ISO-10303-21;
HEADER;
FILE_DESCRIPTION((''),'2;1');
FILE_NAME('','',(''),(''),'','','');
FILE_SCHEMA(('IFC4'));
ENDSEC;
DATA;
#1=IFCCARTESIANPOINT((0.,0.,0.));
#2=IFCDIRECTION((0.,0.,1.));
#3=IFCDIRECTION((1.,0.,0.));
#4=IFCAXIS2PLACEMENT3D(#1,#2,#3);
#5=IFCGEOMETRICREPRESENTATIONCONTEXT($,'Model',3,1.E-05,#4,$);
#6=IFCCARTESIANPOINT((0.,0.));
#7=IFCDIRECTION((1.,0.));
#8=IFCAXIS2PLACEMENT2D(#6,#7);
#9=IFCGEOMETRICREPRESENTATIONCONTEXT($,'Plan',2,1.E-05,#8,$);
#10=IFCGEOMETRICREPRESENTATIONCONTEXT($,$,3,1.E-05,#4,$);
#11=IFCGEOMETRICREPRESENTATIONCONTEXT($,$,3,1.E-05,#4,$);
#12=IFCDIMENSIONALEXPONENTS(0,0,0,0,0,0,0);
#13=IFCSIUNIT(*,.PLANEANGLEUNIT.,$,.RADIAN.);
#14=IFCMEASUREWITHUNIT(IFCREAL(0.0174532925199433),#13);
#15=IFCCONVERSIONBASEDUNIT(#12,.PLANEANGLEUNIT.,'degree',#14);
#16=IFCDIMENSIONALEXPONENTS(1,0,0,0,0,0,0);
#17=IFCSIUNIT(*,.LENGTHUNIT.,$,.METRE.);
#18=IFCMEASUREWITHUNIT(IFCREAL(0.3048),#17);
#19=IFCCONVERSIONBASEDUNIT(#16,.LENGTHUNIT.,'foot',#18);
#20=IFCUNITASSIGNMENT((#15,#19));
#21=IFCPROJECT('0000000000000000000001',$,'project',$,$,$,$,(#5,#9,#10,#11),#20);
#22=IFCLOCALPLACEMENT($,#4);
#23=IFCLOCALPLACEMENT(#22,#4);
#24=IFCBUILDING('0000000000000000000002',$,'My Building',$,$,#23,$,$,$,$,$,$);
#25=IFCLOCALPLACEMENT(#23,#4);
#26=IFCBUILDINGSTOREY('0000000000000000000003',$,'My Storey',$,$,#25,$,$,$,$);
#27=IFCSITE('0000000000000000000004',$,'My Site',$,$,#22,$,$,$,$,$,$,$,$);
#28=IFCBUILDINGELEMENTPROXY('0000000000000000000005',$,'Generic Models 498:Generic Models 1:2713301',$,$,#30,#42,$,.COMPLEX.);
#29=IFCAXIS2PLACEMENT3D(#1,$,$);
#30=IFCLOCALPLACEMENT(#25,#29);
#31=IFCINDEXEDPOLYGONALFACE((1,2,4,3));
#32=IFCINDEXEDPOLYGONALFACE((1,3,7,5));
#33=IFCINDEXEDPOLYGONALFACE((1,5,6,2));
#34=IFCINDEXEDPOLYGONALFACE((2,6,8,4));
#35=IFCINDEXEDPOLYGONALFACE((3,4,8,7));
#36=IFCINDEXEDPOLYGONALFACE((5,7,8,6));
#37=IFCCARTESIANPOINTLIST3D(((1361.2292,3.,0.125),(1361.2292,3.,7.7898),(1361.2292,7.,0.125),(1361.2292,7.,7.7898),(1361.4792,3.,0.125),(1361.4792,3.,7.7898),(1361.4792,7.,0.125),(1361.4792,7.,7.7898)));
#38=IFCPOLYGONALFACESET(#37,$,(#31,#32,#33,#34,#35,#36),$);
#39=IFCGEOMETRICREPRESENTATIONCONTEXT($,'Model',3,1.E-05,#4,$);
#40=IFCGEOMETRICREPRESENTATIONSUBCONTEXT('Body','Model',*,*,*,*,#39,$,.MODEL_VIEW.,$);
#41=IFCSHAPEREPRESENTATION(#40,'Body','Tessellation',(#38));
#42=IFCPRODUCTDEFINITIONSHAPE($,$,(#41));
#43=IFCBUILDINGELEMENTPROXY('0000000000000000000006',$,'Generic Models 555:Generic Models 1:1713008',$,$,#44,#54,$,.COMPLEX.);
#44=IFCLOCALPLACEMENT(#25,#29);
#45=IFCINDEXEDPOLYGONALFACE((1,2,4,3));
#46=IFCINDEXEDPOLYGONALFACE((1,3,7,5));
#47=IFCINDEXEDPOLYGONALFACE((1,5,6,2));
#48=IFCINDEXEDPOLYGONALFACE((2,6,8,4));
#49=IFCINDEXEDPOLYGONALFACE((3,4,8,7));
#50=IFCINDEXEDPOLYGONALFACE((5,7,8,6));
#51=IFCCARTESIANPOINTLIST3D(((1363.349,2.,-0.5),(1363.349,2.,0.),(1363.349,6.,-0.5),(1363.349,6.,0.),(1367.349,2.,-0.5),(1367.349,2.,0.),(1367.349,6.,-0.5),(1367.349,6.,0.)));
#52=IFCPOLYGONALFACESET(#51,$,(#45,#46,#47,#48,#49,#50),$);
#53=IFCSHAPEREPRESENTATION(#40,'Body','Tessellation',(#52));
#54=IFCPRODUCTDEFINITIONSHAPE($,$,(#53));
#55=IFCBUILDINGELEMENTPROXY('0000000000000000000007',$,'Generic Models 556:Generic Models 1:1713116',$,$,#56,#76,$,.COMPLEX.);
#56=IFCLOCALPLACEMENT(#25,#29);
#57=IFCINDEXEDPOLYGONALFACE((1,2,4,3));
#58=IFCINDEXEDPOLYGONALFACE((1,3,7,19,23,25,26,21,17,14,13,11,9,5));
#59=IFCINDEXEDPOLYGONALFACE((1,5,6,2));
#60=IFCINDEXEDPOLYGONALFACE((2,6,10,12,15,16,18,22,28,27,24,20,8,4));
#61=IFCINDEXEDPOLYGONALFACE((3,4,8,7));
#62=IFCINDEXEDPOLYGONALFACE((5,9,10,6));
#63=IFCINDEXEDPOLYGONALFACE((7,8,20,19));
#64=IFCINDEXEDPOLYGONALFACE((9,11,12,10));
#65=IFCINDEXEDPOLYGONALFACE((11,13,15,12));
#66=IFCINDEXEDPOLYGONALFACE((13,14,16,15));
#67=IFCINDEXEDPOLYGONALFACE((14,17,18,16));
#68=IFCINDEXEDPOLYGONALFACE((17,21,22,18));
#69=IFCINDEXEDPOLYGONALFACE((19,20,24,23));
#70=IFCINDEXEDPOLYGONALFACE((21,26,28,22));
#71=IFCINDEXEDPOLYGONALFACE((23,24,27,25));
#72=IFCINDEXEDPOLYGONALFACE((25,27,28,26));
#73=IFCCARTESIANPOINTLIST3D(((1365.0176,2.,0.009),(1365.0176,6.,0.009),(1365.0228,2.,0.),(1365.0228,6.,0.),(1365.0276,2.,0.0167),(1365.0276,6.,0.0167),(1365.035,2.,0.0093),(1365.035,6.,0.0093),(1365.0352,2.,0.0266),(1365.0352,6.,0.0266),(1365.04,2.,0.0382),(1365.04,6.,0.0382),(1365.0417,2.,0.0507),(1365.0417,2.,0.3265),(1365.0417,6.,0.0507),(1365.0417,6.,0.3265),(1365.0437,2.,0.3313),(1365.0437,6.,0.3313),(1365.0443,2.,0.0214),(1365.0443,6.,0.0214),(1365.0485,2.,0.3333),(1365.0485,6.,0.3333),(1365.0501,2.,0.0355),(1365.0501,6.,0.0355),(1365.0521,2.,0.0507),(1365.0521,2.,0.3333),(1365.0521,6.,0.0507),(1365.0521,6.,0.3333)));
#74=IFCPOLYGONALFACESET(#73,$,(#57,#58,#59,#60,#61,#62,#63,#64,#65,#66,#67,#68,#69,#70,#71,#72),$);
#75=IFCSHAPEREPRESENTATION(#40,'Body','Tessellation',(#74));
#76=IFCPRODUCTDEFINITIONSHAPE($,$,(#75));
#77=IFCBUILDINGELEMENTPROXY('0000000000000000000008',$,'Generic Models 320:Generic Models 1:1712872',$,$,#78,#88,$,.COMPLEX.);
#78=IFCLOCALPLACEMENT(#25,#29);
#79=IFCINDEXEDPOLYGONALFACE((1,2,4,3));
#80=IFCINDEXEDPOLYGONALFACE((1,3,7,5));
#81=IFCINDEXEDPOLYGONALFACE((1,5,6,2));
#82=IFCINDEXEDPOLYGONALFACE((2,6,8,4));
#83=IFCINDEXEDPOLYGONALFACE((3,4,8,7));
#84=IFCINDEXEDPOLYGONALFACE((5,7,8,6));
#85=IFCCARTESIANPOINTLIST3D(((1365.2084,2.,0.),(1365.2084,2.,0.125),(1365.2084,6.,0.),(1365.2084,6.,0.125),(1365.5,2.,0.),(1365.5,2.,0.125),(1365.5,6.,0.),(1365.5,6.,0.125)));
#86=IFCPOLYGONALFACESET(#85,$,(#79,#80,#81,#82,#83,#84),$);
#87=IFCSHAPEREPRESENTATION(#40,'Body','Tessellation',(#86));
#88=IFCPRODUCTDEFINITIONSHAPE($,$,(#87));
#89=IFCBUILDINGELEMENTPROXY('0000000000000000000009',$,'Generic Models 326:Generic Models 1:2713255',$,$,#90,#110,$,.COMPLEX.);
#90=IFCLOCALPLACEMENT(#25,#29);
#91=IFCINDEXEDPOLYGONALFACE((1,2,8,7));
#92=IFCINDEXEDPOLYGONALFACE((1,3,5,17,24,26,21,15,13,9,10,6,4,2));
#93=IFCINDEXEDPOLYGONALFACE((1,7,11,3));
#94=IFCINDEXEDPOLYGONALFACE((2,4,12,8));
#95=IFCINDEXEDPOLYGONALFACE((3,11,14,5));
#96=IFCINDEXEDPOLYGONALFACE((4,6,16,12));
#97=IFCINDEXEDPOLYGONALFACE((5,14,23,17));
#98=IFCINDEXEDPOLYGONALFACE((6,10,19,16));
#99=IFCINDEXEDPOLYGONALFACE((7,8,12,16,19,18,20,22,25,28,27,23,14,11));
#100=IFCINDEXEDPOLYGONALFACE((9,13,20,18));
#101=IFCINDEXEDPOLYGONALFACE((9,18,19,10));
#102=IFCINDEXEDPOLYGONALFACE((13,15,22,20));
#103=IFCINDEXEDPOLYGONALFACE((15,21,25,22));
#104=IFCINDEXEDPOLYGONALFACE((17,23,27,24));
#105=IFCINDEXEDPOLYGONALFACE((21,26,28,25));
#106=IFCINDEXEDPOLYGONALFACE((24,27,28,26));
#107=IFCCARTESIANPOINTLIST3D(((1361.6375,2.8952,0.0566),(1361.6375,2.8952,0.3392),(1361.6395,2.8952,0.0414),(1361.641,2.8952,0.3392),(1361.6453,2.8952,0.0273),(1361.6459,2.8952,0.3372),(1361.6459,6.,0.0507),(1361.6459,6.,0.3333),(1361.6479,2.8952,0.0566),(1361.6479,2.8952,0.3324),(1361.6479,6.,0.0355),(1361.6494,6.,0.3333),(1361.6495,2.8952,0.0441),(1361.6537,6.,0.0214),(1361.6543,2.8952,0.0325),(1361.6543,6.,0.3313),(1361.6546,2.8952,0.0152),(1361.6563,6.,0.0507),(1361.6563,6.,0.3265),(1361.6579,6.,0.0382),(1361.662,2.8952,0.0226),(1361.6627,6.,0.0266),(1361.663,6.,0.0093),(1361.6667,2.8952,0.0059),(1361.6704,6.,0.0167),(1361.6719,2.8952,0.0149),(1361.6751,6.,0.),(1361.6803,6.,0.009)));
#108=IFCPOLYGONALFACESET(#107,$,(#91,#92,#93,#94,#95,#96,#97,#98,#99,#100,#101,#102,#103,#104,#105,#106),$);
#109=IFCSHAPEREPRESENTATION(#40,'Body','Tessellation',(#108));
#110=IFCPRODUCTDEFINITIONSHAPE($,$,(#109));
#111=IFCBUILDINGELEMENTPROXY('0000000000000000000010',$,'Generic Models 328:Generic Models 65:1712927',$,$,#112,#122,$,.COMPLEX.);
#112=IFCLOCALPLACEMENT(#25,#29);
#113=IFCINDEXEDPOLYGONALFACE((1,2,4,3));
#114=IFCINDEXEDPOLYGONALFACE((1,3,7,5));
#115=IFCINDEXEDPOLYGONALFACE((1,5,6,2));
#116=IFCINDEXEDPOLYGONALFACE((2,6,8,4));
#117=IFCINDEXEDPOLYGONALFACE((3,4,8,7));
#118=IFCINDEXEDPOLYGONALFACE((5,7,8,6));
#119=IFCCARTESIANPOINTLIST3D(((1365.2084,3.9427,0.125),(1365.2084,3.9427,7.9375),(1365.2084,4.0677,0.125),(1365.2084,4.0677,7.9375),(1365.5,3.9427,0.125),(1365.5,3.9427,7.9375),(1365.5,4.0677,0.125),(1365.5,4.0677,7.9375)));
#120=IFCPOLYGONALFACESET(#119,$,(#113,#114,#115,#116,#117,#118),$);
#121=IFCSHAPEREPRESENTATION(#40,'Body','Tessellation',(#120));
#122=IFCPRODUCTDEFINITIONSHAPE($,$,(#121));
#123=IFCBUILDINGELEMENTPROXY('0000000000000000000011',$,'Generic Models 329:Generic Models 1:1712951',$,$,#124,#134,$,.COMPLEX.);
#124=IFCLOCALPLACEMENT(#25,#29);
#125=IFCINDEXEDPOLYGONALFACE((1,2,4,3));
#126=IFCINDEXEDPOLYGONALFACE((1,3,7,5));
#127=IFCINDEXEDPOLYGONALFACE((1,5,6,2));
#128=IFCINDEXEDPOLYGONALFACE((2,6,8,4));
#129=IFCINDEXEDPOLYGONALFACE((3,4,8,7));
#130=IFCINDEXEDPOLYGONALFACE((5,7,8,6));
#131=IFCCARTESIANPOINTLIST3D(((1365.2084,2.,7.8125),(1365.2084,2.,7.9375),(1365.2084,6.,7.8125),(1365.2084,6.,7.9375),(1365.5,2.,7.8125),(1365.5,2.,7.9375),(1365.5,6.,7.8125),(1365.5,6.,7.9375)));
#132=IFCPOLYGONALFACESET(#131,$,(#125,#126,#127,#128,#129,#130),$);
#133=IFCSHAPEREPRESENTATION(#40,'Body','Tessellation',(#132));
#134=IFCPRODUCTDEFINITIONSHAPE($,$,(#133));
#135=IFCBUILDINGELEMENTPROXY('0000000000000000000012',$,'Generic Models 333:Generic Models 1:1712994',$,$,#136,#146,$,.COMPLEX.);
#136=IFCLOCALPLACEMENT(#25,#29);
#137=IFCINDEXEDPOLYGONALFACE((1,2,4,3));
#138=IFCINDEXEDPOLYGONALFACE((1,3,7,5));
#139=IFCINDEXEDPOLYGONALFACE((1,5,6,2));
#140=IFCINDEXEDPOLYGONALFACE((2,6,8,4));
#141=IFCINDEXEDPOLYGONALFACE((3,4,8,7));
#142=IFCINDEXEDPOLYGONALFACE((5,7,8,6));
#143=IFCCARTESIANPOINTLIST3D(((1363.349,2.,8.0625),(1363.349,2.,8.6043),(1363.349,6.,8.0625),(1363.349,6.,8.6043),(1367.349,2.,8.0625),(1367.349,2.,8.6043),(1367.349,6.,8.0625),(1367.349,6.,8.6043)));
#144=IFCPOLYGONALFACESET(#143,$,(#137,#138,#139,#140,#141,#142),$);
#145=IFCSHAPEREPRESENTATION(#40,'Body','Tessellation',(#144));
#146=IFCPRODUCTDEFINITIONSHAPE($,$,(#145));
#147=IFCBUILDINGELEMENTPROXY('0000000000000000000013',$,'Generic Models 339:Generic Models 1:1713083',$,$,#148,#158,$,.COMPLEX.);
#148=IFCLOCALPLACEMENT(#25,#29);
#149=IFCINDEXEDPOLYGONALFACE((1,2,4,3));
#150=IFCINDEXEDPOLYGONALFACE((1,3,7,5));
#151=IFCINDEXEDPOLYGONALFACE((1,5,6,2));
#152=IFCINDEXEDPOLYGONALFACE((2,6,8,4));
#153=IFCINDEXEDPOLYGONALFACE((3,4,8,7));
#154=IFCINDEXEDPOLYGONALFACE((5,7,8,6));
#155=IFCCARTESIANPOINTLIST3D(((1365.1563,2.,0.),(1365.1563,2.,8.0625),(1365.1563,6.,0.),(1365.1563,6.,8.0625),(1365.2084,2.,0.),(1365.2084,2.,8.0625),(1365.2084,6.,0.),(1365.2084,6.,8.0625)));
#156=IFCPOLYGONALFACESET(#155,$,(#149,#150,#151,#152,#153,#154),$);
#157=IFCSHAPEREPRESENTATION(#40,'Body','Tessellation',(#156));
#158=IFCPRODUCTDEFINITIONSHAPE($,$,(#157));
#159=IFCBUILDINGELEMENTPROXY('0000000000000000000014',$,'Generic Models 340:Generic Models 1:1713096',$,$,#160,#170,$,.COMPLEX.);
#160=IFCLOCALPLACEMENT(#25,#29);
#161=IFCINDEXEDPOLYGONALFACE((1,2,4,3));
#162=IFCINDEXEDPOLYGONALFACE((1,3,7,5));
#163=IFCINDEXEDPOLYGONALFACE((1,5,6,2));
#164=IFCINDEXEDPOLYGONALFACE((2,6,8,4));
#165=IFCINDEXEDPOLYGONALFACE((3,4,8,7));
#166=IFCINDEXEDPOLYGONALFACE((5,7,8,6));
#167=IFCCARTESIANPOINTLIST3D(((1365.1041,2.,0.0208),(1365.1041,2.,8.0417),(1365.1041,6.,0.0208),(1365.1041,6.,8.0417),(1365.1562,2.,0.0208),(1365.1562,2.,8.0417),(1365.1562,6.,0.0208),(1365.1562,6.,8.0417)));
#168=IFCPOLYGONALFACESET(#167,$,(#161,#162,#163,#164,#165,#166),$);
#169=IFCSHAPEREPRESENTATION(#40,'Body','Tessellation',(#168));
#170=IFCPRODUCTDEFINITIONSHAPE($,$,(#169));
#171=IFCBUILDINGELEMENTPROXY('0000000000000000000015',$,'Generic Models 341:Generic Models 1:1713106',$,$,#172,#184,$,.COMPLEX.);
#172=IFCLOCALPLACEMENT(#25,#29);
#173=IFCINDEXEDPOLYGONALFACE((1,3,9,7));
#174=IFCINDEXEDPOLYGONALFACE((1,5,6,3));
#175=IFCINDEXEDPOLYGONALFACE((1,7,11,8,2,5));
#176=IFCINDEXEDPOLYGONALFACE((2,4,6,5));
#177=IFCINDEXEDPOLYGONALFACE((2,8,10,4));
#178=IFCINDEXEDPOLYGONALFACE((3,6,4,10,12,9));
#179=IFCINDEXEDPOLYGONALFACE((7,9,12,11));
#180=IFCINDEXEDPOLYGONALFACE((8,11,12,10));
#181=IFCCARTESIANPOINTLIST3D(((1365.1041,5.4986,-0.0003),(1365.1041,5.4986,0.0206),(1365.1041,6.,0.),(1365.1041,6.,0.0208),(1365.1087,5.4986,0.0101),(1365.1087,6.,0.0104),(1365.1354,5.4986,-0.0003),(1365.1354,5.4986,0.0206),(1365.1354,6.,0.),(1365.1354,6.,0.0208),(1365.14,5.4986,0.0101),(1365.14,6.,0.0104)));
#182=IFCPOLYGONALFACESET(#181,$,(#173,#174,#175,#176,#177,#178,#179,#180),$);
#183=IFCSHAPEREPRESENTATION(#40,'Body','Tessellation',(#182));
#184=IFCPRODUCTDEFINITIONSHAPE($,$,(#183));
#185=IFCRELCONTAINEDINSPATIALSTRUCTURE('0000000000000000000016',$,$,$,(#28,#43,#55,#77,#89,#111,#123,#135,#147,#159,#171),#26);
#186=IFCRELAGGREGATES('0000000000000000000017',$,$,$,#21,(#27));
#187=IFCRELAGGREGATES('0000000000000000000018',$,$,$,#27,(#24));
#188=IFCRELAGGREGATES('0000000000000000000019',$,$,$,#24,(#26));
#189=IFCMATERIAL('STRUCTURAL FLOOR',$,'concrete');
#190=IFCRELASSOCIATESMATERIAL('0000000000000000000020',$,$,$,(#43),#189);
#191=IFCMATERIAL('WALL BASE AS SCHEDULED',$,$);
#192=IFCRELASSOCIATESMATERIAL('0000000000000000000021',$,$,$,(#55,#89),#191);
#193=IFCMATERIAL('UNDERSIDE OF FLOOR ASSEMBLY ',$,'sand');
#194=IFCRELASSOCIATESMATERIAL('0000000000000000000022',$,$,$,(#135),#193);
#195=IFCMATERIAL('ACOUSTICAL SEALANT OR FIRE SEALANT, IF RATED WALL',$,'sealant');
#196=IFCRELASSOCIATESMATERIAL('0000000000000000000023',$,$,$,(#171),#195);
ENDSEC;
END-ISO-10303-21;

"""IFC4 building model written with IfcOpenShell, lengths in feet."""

from ifc_helpers import new_model, entity, si_unit, converted_unit, frame, origin_with_axes, origin_2d_with_axis, place, context, subcontext, project, spatial, polyline, outline, extrude, material, element, save


model = new_model("IFC4")

# Units and contexts
model_context_1 = context("Model", 3, precision=1e-05, world=origin_with_axes())
plan_context = context("Plan", 2, precision=1e-05, world=origin_2d_with_axis())
model_context_2 = context("Model", 3, precision=1e-05, world=origin_with_axes())
context_of_model_1 = context(None, 3, precision=1e-05, world=origin_with_axes())
context_of_model_2 = context(None, 3, precision=1e-05, world=origin_with_axes())
body_context = subcontext(model_context_2, "Body", "Model", "MODEL_VIEW")
ifc_project = project(units=[converted_unit("PLANEANGLEUNIT", "degree", entity("IfcReal", 0.0174532925199433), si_unit("PLANEANGLEUNIT", "RADIAN"), dimensions=[0, 0, 0, 0, 0, 0, 0]), converted_unit("LENGTHUNIT", "foot", entity("IfcReal", 0.3048), si_unit("LENGTHUNIT", "METRE"), dimensions=[1, 0, 0, 0, 0, 0, 0])], contexts=[model_context_1, plan_context, context_of_model_1, context_of_model_2])

# Site, building, storey
site_placement = place(None, origin_with_axes())
site = spatial("IfcSite", under=ifc_project, at=site_placement, Name="My Site")
building_placement = place(site_placement, origin_with_axes())
building = spatial("IfcBuilding", under=site, at=building_placement, Name="My Building")
storey_placement = place(building_placement, origin_with_axes())
storey = spatial("IfcBuildingStorey", under=building, at=storey_placement, Name="My Storey")

# Building element proxies
proxy_1_placement = place(storey_placement, frame((1361.2292, 3.0, 0.125), z_axis=(0.0, 0.0, 1.0), x_axis=(0.0, 1.0, 0.0)))
element("IfcBuildingElementProxy", 1, at=proxy_1_placement, inside=storey, Name="Generic Models 498:Generic Models 1:2713301", PredefinedType="COMPLEX", context=body_context, shape_type="SweptSolid", body=[
    extrude(outline(polyline([(-2.0, -0.125), (2.0, -0.125), (2.0, 0.125), (-2.0, 0.125), (-2.0, -0.125)])), frame((2.0, -0.125, 0.0), z_axis=(0.0, 0.0, -1.0), x_axis=(-1.0, 0.0, 0.0)), (0.0, 0.0, -1.0), 7.6648),
])
ifc_material_1 = material(Name="ACOUSTICAL SEALANT OR FIRE SEALANT, IF RATED WALL", Category="sealant")
ifc_material_2 = material(Name="STRUCTURAL FLOOR", Category="concrete")
proxy_2_placement = place(storey_placement, frame((1363.349, 6.0, -0.5), z_axis=(0.0, -1.0, 0.0), x_axis=(0.0, 0.0, 1.0)))
element("IfcBuildingElementProxy", 2, at=proxy_2_placement, inside=storey, material=ifc_material_2, Name="Generic Models 555:Generic Models 1:1713008", PredefinedType="COMPLEX", context=body_context, shape_type="SweptSolid", body=[
    extrude(outline(polyline([(-0.25, -2.0), (0.25, -2.0), (0.25, 2.0), (-0.25, 2.0), (-0.25, -2.0)])), frame((0.25, -2.0, 0.0), z_axis=(0.0, 0.0, -1.0), x_axis=(1.0, 0.0, 0.0)), (0.0, 0.0, -1.0), 4.0),
])
ifc_material_3 = material(Name="WALL BASE AS SCHEDULED")
proxy_3_placement = place(storey_placement, frame((1365.0176, 6.0, 0.0), z_axis=(0.0, -1.0, 0.0), x_axis=(0.0, 0.0, 1.0)))
element("IfcBuildingElementProxy", 3, at=proxy_3_placement, inside=storey, material=ifc_material_3, Name="Generic Models 556:Generic Models 1:1713116", PredefinedType="COMPLEX", context=body_context, shape_type="SweptSolid", body=[
    extrude(outline(polyline([(0.2205, 0.0), (0.2206, 0.0036), (-0.0618, 0.0152), (-0.077, 0.0138), (-0.0914, 0.0086), (-0.1038, -0.0002), (-0.1136, -0.012), (-0.1048, -0.0175), (-0.0968, -0.0079), (-0.0865, -0.0007), (-0.0747, 0.0037), (-0.0622, 0.0048), (0.2133, -0.0066), (0.2183, -0.0048), (0.2205, 0.0)])), frame((0.113, -0.0218, 0.0), z_axis=(0.0, 0.0, -1.0), x_axis=(0.999153, -0.041137, 0.0)), (0.0, 0.0, -1.0), 4.0),
])
proxy_4_placement = place(storey_placement, frame((1365.2084, 6.0, 0.0), z_axis=(0.0, -1.0, 0.0), x_axis=(0.0, 0.0, 1.0)))
element("IfcBuildingElementProxy", 4, at=proxy_4_placement, inside=storey, Name="Generic Models 320:Generic Models 1:1712872", PredefinedType="COMPLEX", context=body_context, shape_type="SweptSolid", body=[
    extrude(outline(polyline([(-0.0625, -0.1458), (0.0625, -0.1458), (0.0625, 0.1458), (-0.0625, 0.1458), (-0.0625, -0.1458)])), frame((0.0625, -0.1458, 0.0), z_axis=(0.0, 0.0, -1.0), x_axis=(1.0, 0.0, 0.0)), (0.0, 0.0, -1.0), 4.0),
])
proxy_5_placement = place(storey_placement, frame((1361.6459, 6.0, 0.0), z_axis=(0.0, -1.0, 0.0), x_axis=(0.0, 0.0, 1.0)))
element("IfcBuildingElementProxy", 5, at=proxy_5_placement, inside=storey, material=ifc_material_3, Name="Generic Models 326:Generic Models 1:2713255", PredefinedType="COMPLEX", context=body_context, shape_type="SweptSolid", body=[
    extrude(outline(polyline([(-0.2134, 0.0022), (0.0624, 0.0022), (0.0748, 0.0006), (0.0864, -0.0042), (0.0964, -0.0119), (0.104, -0.0218), (0.113, -0.0166), (0.1037, -0.0045), (0.0916, 0.0048), (0.0775, 0.0106), (0.0624, 0.0126), (-0.2203, 0.0126), (-0.2203, 0.0091), (-0.2183, 0.0042), (-0.2134, 0.0022)])), frame((0.113, -0.0126, 0.0), z_axis=(0.0, 0.0, -1.0), x_axis=(-1.0, 0.0, 0.0)), (-0.001902, 0.002712, -0.999995), 3.1048),
])
proxy_6_placement = place(storey_placement, frame((1365.2084, 3.9427, 0.125), z_axis=(0.0, 0.0, 1.0), x_axis=(1.0, 0.0, 0.0)))
element("IfcBuildingElementProxy", 6, at=proxy_6_placement, inside=storey, Name="Generic Models 328:Generic Models 65:1712927", PredefinedType="COMPLEX", context=body_context, shape_type="SweptSolid", body=[
    extrude(outline(polyline([(-0.1458, -0.0625), (0.1458, -0.0625), (0.1458, 0.0625), (-0.1458, 0.0625), (-0.1458, -0.0625)])), frame((0.1458, 0.0625, 0.0), z_axis=(0.0, 0.0, -1.0), x_axis=(-1.0, 0.0, 0.0)), (0.0, 0.0, -1.0), 7.8125),
])
proxy_7_placement = place(storey_placement, frame((1365.2084, 6.0, 7.8125), z_axis=(0.0, -1.0, 0.0), x_axis=(0.0, 0.0, 1.0)))
element("IfcBuildingElementProxy", 7, at=proxy_7_placement, inside=storey, Name="Generic Models 329:Generic Models 1:1712951", PredefinedType="COMPLEX", context=body_context, shape_type="SweptSolid", body=[
    extrude(outline(polyline([(-0.1458, -0.0625), (0.1458, -0.0625), (0.1458, 0.0625), (-0.1458, 0.0625), (-0.1458, -0.0625)])), frame((0.0625, -0.1458, 0.0), z_axis=(0.0, 0.0, -1.0), x_axis=(0.0, 1.0, 0.0)), (0.0, 0.0, -1.0), 4.0),
])
ifc_material_4 = material(Name="UNDERSIDE OF FLOOR ASSEMBLY ", Category="sand")
proxy_8_placement = place(storey_placement, frame((1363.349, 6.0, 8.0625), z_axis=(0.0, -1.0, 0.0), x_axis=(0.0, 0.0, 1.0)))
element("IfcBuildingElementProxy", 8, at=proxy_8_placement, inside=storey, material=ifc_material_4, Name="Generic Models 333:Generic Models 1:1712994", PredefinedType="COMPLEX", context=body_context, shape_type="SweptSolid", body=[
    extrude(outline(polyline([(-0.2709, -2.0), (0.2709, -2.0), (0.2709, 2.0), (-0.2709, 2.0), (-0.2709, -2.0)])), frame((0.2709, -2.0, 0.0), z_axis=(0.0, 0.0, -1.0), x_axis=(1.0, 0.0, 0.0)), (0.0, 0.0, -1.0), 4.0),
])
proxy_9_placement = place(storey_placement, frame((1365.1563, 6.0, 0.0), z_axis=(0.0, -1.0, 0.0), x_axis=(0.0, 0.0, 1.0)))
element("IfcBuildingElementProxy", 9, at=proxy_9_placement, inside=storey, Name="Generic Models 339:Generic Models 1:1713083", PredefinedType="COMPLEX", context=body_context, shape_type="SweptSolid", body=[
    extrude(outline(polyline([(-4.0312, -0.026), (4.0312, -0.026), (4.0312, 0.026), (-4.0312, 0.026), (-4.0312, -0.026)])), frame((4.0312, -0.026, 0.0), z_axis=(0.0, 0.0, -1.0), x_axis=(-1.0, 0.0, 0.0)), (0.0, 0.0, -1.0), 4.0),
])
proxy_10_placement = place(storey_placement, frame((1365.1041, 6.0, 0.0208), z_axis=(0.0, -1.0, 0.0), x_axis=(0.0, 0.0, 1.0)))
element("IfcBuildingElementProxy", 10, at=proxy_10_placement, inside=storey, Name="Generic Models 340:Generic Models 1:1713096", PredefinedType="COMPLEX", context=body_context, shape_type="SweptSolid", body=[
    extrude(outline(polyline([(-0.026, -4.0104), (0.026, -4.0104), (0.026, 4.0104), (-0.026, 4.0104), (-0.026, -4.0104)])), frame((4.0104, -0.026, 0.0), z_axis=(0.0, 0.0, -1.0), x_axis=(0.0, 1.0, 0.0)), (0.0, 0.0, -1.0), 4.0),
])
proxy_11_placement = place(storey_placement, frame((1365.1041, 6.0, 0.0), z_axis=(0.0, -1.0, 0.0), x_axis=(0.0, 0.0, 1.0)))
element("IfcBuildingElementProxy", 11, at=proxy_11_placement, inside=storey, material=ifc_material_1, Name="Generic Models 341:Generic Models 1:1713106", PredefinedType="COMPLEX", context=body_context, shape_type="SweptSolid", body=[
    extrude(outline(polyline([(0.0201, 0.0), (-0.0066, 0.0162), (-0.016, 0.0097), (-0.0175, -0.0016), (0.0093, -0.0178), (0.0107, -0.0065), (0.0201, 0.0)])), frame((0.0104, -0.0172, 0.0), z_axis=(0.0, 0.0, -1.0), x_axis=(0.51911, 0.854708, 0.0)), (-0.000285, -0.000479, -1.0), 0.5014),
])

save(model, "model.ifc")
